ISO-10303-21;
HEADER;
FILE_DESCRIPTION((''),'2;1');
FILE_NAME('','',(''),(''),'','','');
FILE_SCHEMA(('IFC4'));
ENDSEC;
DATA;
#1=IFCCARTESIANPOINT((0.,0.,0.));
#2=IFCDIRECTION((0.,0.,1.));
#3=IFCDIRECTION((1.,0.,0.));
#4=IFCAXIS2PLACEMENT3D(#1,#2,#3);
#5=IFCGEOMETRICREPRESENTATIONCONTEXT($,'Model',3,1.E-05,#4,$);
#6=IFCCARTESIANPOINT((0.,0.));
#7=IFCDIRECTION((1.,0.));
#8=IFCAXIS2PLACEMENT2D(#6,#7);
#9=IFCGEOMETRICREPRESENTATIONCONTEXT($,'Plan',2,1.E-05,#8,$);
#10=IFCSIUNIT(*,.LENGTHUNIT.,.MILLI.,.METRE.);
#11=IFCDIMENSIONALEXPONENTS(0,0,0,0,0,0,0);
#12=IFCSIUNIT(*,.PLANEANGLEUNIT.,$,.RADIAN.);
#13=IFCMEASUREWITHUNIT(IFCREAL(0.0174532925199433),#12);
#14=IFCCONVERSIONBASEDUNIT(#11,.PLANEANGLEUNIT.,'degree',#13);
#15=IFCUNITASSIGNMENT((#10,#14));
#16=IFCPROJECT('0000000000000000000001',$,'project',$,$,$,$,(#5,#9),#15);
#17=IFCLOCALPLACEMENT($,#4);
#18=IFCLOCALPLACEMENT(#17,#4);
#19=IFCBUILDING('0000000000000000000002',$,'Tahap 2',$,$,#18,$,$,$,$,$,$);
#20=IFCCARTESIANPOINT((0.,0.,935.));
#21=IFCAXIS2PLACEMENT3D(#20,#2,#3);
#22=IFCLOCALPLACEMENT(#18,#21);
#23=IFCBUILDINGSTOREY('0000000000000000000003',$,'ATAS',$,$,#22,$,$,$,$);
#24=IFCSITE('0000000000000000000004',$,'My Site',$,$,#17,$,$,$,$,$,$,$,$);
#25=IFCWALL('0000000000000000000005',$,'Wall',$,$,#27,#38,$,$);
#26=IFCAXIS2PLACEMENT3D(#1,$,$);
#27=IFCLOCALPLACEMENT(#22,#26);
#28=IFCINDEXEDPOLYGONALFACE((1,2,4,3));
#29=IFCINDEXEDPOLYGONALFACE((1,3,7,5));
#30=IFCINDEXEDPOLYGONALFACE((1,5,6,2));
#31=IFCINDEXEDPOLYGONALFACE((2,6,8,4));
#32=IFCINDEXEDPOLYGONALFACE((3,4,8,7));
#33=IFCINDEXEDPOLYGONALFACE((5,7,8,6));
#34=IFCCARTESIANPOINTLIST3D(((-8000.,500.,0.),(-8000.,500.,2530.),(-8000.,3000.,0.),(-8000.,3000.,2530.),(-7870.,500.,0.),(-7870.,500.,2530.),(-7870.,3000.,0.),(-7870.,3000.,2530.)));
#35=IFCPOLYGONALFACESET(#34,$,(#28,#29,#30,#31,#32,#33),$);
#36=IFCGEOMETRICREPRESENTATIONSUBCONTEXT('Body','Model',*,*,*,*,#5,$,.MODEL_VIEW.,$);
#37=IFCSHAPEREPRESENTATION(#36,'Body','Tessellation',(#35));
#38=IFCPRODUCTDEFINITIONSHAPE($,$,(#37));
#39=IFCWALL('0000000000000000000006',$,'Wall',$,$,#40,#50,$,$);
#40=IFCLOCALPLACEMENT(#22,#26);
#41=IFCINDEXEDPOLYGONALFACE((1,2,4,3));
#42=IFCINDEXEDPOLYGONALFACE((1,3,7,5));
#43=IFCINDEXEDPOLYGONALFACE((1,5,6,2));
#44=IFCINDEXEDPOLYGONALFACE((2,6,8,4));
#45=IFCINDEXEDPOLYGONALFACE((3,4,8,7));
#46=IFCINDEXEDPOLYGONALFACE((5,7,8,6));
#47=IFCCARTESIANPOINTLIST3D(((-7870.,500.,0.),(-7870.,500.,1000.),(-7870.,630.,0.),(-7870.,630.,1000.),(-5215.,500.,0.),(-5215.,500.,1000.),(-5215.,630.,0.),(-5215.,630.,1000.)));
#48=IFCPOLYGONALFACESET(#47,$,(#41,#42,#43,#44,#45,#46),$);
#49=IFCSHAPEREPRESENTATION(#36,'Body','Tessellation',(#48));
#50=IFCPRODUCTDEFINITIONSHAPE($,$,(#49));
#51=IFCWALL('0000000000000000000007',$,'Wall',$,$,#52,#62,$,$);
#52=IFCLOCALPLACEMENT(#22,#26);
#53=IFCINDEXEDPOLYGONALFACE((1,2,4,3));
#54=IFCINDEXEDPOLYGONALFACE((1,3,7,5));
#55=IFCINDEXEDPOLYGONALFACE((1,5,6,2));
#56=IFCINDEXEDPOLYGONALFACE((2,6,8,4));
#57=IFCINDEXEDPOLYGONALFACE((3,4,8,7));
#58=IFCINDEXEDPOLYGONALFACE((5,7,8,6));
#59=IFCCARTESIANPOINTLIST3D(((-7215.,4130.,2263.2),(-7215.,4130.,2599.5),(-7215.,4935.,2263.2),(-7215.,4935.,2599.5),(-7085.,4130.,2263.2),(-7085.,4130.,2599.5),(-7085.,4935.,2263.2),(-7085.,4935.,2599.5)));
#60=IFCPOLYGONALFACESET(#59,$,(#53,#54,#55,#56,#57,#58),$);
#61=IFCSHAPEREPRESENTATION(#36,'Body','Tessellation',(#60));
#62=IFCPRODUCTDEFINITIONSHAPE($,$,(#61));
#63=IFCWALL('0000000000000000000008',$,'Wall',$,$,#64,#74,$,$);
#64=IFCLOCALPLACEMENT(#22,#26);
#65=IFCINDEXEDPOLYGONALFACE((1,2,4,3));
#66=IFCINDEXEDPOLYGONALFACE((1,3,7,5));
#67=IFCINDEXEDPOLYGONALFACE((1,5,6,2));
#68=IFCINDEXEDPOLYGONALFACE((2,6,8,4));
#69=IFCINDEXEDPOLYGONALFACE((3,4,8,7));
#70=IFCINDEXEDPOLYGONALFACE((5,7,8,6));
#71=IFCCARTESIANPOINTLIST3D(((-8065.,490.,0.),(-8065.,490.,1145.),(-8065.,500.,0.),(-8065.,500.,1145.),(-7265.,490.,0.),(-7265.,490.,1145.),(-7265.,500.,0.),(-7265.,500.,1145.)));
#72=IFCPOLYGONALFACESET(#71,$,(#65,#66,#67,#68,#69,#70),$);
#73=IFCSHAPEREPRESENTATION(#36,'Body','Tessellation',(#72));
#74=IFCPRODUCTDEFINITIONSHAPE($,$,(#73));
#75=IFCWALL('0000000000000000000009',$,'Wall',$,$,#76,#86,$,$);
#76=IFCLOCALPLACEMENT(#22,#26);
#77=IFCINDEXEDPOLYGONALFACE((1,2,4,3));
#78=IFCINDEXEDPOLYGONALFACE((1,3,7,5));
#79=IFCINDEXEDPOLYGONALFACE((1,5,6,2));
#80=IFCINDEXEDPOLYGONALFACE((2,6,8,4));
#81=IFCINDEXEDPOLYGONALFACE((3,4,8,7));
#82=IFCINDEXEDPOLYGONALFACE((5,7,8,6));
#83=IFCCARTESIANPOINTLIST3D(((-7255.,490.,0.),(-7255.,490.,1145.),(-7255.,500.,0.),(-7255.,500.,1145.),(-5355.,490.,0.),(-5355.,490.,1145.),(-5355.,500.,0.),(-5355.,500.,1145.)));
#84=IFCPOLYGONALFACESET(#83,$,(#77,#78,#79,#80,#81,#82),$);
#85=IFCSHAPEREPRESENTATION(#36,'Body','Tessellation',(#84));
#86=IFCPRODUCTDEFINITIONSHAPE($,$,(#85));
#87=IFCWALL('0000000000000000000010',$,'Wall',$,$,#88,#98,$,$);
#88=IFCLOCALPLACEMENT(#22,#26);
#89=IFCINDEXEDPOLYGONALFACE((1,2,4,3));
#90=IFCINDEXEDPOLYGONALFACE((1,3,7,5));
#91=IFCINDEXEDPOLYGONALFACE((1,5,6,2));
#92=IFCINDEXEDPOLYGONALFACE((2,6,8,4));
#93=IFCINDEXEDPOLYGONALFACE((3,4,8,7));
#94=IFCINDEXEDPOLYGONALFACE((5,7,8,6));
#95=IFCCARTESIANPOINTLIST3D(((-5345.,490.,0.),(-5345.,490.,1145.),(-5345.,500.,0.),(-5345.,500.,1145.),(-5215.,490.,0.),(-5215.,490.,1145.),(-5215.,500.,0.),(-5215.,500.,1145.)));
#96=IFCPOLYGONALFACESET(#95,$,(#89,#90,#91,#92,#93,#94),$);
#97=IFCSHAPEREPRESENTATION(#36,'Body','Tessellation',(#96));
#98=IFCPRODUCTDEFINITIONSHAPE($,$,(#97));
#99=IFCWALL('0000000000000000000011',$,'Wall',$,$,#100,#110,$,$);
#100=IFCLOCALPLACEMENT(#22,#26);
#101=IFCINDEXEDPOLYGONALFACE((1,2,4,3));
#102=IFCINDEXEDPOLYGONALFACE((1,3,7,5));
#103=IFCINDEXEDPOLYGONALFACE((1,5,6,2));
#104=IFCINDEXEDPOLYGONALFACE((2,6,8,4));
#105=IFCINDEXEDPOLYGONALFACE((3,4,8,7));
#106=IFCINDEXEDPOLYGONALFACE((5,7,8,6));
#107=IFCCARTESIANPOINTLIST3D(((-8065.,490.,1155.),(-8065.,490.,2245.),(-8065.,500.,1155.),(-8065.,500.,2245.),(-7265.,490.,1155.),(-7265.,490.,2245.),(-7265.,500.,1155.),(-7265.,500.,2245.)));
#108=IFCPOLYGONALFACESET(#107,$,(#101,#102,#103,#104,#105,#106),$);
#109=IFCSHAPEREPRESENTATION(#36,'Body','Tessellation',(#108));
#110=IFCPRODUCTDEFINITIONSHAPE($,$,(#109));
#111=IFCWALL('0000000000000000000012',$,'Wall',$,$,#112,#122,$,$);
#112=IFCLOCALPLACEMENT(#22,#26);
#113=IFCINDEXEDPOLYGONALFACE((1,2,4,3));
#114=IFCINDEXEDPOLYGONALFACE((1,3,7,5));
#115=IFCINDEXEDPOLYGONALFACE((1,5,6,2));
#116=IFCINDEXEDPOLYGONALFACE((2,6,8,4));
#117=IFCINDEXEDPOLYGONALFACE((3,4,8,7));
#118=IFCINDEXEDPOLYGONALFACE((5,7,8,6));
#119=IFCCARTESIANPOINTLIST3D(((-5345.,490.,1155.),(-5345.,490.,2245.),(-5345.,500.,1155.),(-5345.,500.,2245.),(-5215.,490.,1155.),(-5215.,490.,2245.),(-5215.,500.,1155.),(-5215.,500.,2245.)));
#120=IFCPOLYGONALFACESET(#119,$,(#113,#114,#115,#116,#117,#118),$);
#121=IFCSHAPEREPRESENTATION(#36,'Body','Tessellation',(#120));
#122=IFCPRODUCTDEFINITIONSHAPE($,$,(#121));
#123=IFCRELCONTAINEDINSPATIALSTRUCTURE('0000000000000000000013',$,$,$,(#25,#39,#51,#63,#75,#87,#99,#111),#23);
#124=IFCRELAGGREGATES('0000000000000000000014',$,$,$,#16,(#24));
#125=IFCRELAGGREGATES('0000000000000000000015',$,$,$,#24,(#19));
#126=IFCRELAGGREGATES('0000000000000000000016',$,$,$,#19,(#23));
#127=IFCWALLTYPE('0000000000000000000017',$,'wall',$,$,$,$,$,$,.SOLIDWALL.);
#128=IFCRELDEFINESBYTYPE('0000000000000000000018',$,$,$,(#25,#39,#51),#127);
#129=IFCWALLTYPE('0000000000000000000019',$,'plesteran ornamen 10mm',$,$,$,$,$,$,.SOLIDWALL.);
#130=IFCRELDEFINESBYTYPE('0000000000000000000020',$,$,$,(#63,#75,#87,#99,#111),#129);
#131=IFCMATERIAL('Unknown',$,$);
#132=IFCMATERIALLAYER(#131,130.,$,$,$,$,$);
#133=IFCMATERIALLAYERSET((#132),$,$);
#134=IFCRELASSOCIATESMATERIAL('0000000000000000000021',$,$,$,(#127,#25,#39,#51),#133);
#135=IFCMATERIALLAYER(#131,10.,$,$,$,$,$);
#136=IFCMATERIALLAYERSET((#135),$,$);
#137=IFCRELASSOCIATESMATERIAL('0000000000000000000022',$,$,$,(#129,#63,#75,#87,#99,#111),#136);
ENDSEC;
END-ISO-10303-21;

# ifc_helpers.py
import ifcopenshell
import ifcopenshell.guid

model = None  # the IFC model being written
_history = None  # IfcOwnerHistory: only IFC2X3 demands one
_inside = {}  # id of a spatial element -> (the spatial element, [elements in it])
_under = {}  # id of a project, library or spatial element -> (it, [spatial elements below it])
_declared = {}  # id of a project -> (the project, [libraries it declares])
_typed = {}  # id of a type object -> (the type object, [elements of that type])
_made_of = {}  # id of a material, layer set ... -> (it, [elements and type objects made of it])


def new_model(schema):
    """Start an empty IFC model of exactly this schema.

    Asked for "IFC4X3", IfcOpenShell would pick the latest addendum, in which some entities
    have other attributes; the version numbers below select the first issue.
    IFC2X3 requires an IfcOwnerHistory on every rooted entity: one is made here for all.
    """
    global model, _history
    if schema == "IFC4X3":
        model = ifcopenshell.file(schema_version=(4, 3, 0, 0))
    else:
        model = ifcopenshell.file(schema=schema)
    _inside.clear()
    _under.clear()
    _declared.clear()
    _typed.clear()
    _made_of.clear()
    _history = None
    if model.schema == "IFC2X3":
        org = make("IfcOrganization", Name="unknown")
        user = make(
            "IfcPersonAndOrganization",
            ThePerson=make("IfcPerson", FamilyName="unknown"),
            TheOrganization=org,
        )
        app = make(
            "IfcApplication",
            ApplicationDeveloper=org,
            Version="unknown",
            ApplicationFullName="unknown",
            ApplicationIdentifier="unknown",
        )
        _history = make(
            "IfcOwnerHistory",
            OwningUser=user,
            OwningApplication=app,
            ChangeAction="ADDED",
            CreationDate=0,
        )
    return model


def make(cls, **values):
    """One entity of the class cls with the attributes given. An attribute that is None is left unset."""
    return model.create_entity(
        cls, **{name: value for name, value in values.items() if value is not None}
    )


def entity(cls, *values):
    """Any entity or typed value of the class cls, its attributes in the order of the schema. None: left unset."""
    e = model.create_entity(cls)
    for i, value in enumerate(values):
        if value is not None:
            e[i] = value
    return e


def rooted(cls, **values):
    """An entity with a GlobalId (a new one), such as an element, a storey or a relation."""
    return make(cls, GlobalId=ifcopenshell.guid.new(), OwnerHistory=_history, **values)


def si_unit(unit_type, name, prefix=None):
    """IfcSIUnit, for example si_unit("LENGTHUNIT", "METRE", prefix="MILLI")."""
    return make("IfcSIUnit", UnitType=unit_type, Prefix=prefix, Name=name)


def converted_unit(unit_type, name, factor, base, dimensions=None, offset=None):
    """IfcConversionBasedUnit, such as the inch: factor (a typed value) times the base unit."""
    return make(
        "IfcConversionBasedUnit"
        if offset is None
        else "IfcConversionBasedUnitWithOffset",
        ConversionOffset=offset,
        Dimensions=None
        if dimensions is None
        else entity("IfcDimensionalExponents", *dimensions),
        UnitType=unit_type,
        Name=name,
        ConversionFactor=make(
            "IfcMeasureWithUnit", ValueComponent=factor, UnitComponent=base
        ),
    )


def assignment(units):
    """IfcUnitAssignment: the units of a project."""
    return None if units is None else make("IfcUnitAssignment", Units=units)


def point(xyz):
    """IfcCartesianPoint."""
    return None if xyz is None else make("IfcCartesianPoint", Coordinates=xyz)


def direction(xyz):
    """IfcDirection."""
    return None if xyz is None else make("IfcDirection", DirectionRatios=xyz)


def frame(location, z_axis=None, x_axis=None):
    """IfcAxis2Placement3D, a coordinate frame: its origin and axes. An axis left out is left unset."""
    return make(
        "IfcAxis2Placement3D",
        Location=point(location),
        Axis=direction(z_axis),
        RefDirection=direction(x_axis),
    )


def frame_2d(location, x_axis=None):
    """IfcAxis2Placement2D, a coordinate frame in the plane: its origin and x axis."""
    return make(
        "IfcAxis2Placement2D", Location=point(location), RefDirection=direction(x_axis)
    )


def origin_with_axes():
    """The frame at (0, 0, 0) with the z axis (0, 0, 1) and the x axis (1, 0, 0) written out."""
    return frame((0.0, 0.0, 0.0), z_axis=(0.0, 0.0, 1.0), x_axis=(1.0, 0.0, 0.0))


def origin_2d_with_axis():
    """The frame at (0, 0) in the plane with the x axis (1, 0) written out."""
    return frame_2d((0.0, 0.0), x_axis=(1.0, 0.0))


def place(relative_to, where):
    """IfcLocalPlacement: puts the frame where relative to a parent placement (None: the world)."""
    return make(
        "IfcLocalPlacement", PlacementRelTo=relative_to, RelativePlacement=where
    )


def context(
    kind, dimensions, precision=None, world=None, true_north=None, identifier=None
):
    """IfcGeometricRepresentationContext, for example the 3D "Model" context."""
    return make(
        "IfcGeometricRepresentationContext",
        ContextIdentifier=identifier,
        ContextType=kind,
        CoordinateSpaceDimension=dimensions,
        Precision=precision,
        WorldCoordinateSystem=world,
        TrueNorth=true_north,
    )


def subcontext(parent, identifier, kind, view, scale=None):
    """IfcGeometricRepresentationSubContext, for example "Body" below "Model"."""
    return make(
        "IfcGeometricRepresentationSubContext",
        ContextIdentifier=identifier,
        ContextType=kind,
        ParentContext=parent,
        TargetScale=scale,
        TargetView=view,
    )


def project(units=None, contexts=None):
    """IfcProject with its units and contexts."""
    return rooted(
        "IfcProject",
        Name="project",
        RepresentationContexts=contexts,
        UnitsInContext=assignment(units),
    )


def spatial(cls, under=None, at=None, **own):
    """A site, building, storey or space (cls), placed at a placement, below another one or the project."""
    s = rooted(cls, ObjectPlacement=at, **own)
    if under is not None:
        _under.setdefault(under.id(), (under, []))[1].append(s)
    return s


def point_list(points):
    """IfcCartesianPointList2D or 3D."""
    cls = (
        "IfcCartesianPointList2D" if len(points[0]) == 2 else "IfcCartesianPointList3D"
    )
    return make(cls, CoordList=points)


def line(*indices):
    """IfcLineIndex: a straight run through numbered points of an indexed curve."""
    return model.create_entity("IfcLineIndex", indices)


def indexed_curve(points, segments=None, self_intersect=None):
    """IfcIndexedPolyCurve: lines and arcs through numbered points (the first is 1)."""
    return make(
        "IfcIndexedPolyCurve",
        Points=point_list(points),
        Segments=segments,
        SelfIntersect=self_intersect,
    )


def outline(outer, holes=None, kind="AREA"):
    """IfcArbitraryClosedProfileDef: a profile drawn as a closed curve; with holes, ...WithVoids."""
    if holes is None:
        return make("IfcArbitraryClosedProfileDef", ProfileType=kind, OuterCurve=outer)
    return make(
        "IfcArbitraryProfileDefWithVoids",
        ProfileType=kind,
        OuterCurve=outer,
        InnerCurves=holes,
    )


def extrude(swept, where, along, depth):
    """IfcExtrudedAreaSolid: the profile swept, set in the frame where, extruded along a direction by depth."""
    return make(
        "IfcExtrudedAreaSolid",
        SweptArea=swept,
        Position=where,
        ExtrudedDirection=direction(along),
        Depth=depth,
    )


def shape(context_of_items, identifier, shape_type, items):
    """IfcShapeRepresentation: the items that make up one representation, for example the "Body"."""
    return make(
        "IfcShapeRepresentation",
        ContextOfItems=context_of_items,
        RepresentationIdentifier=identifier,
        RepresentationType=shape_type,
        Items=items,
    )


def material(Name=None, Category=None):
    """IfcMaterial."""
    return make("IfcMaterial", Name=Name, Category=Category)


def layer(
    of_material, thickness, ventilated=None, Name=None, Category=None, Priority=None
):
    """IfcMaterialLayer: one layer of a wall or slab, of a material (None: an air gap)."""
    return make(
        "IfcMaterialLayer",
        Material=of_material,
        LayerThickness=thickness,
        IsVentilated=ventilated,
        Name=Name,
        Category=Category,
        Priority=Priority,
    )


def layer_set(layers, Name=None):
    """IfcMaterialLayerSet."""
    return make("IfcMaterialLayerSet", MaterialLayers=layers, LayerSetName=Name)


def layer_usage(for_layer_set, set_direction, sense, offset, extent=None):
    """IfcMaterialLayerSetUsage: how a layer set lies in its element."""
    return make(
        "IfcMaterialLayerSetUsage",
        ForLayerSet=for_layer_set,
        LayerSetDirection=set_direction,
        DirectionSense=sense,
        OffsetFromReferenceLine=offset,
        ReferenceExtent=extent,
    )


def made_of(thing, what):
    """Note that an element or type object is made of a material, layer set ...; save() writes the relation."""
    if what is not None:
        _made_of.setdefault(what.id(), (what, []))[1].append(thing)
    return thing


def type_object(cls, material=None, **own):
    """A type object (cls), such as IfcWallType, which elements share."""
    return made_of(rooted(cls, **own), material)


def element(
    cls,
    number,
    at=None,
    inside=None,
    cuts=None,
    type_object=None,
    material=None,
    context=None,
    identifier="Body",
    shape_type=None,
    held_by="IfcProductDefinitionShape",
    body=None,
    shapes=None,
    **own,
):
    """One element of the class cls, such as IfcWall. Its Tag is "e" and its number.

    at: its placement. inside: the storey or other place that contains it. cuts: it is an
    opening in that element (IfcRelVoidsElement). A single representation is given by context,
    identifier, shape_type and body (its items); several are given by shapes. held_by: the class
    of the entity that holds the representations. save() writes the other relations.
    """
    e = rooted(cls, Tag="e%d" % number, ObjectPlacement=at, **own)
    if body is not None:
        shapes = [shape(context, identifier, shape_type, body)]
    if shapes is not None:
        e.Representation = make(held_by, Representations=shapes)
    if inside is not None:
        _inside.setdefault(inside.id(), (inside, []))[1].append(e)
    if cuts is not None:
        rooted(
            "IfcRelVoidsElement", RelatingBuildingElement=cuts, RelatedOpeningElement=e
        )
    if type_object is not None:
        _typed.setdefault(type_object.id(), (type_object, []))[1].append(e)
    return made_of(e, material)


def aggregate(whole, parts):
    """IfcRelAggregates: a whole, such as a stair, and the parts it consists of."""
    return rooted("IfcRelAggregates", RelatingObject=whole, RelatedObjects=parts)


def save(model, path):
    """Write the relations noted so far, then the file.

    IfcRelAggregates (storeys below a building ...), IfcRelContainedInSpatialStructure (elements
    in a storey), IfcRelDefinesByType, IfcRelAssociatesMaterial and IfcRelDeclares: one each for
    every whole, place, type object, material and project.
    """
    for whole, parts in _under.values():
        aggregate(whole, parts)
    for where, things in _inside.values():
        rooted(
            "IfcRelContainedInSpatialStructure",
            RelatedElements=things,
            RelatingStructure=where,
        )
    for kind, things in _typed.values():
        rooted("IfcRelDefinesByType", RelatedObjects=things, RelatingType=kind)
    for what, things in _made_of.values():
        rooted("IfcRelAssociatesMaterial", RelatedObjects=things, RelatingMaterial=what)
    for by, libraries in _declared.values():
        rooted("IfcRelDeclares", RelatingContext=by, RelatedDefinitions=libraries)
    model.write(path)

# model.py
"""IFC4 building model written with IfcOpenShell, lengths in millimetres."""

from ifc_helpers import new_model, entity, si_unit, converted_unit, frame, origin_with_axes, origin_2d_with_axis, place, context, subcontext, project, spatial, line, indexed_curve, outline, extrude, material, layer, layer_set, layer_usage, type_object, element, save


model = new_model("IFC4")

# Units and contexts
model_context = context("Model", 3, precision=1e-05, world=origin_with_axes())
plan_context = context("Plan", 2, precision=1e-05, world=origin_2d_with_axis())
body_context_1 = subcontext(model_context, "Body", "Model", "MODEL_VIEW")
ifc_project = project(units=[si_unit("LENGTHUNIT", "METRE", prefix="MILLI"), converted_unit("PLANEANGLEUNIT", "degree", entity("IfcReal", 0.0174532925199433), si_unit("PLANEANGLEUNIT", "RADIAN"), dimensions=[0, 0, 0, 0, 0, 0, 0])], contexts=[model_context, plan_context])

# Site, building, storey
site_placement = place(None, origin_with_axes())
site = spatial("IfcSite", under=ifc_project, at=site_placement, Name="My Site")
building_placement = place(site_placement, origin_with_axes())
building = spatial("IfcBuilding", under=site, at=building_placement, Name="Tahap 2")
storey_placement = place(building_placement, frame((0.0, 0.0, 935.0), z_axis=(0.0, 0.0, 1.0), x_axis=(1.0, 0.0, 0.0)))
storey = spatial("IfcBuildingStorey", under=building, at=storey_placement, Name="ATAS")

# Shared definitions
ifc_material_1 = material(Name="Unknown")
ifc_layer_1 = layer(ifc_material_1, 130.0)
ifc_layer_set_1 = layer_set([ifc_layer_1])
wall_type_1 = type_object("IfcWallType", Name="wall", PredefinedType="SOLIDWALL", material=ifc_layer_set_1)

# Wall
ifc_layer_usage_1 = layer_usage(ifc_layer_set_1, "AXIS2", "NEGATIVE", 0.0)
wall_1_placement = place(storey_placement, frame((-8000.0, 500.0, 0.0), z_axis=(0.0, 0.0, 1.0), x_axis=(0.0, 1.0, 0.0)))
element("IfcWall", 1, at=wall_1_placement, inside=storey, type_object=wall_type_1, material=ifc_layer_usage_1, Name="Wall", context=body_context_1, shape_type="SweptSolid", body=[
    extrude(outline(indexed_curve([(0.0, -130.0), (0.0, 0.0), (2500.0, 0.0), (2500.0, -130.0)], segments=[line(1, 2, 3, 4, 1)])), origin_with_axes(), (0.0, 0.0, 1.0), 2530.0),
])

# Walls
ifc_layer_usage_2 = layer_usage(ifc_layer_set_1, "AXIS2", "POSITIVE", 0.0)
wall_2_placement = place(storey_placement, frame((-7870.0, 500.0, 0.0), z_axis=(0.0, 0.0, 1.0), x_axis=(1.0, 0.0, 0.0)))
element("IfcWall", 2, at=wall_2_placement, inside=storey, type_object=wall_type_1, material=ifc_layer_usage_2, Name="Wall", context=body_context_1, shape_type="SweptSolid", body=[
    extrude(outline(indexed_curve([(0.0, 0.0), (0.0, 130.0), (2655.0, 130.0), (2655.0, 0.0)], segments=[line(1, 2, 3, 4, 1)])), origin_with_axes(), (0.0, 0.0, 1.0), 1000.0),
])
ifc_layer_usage_3 = layer_usage(ifc_layer_set_1, "AXIS2", "NEGATIVE", 0.0)
wall_3_placement = place(storey_placement, frame((-7085.0, 4935.0, 2263.2), z_axis=(0.0, 0.0, 1.0), x_axis=(-0.000001, -1.0, 0.0)))
element("IfcWall", 3, at=wall_3_placement, inside=storey, type_object=wall_type_1, material=ifc_layer_usage_3, Name="Wall", context=body_context_1, shape_type="SweptSolid", body=[
    extrude(outline(indexed_curve([(0.0, -130.0), (0.0, 0.0), (805.0, 0.0), (805.0, -130.0)], segments=[line(1, 2, 3, 4, 1)])), origin_with_axes(), (0.0, 0.0, 1.0), 336.3),
])
ifc_layer_2 = layer(ifc_material_1, 10.0)
ifc_layer_set_2 = layer_set([ifc_layer_2])
ifc_layer_usage_4 = layer_usage(ifc_layer_set_2, "AXIS2", "NEGATIVE", 0.0)
wall_type_2 = type_object("IfcWallType", Name="plesteran ornamen 10mm", PredefinedType="SOLIDWALL", material=ifc_layer_set_2)
wall_4_placement = place(storey_placement, frame((-8065.0, 500.0, 0.0), z_axis=(0.0, 0.0, 1.0), x_axis=(1.0, 0.0, 0.0)))
element("IfcWall", 4, at=wall_4_placement, inside=storey, type_object=wall_type_2, material=ifc_layer_usage_4, Name="Wall", context=body_context_1, shape_type="SweptSolid", body=[
    extrude(outline(indexed_curve([(0.0, -10.0), (0.0, 0.0), (800.0, 0.0), (800.0, -10.0)], segments=[line(1, 2, 3, 4, 1)])), origin_with_axes(), (0.0, 0.0, 1.0), 1145.0),
])
ifc_layer_usage_5 = layer_usage(ifc_layer_set_2, "AXIS2", "NEGATIVE", 0.0)
wall_5_placement = place(storey_placement, frame((-7255.0, 500.0, 0.0), z_axis=(0.0, 0.0, 1.0), x_axis=(1.0, 0.0, 0.0)))
element("IfcWall", 5, at=wall_5_placement, inside=storey, type_object=wall_type_2, material=ifc_layer_usage_5, Name="Wall", context=body_context_1, shape_type="SweptSolid", body=[
    extrude(outline(indexed_curve([(0.0, -10.0), (0.0, 0.0), (1900.0, 0.0), (1900.0, -10.0)], segments=[line(1, 2, 3, 4, 1)])), origin_with_axes(), (0.0, 0.0, 1.0), 1145.0),
])
ifc_layer_usage_6 = layer_usage(ifc_layer_set_2, "AXIS2", "NEGATIVE", 0.0)
wall_6_placement = place(storey_placement, frame((-5345.0, 500.0, 0.0), z_axis=(0.0, 0.0, 1.0), x_axis=(1.0, 0.0, 0.0)))
element("IfcWall", 6, at=wall_6_placement, inside=storey, type_object=wall_type_2, material=ifc_layer_usage_6, Name="Wall", context=body_context_1, shape_type="SweptSolid", body=[
    extrude(outline(indexed_curve([(0.0, -10.0), (0.0, 0.0), (130.0, 0.0), (130.0, -10.0)], segments=[line(1, 2, 3, 4, 1)])), origin_with_axes(), (0.0, 0.0, 1.0), 1145.0),
])
ifc_layer_usage_7 = layer_usage(ifc_layer_set_2, "AXIS2", "NEGATIVE", 0.0)
wall_7_placement = place(storey_placement, frame((-8065.0, 500.0, 1155.0), z_axis=(0.0, 0.0, 1.0), x_axis=(1.0, 0.0, 0.0)))
element("IfcWall", 7, at=wall_7_placement, inside=storey, type_object=wall_type_2, material=ifc_layer_usage_7, Name="Wall", context=body_context_1, shape_type="SweptSolid", body=[
    extrude(outline(indexed_curve([(0.0, -10.0), (0.0, 0.0), (800.0, 0.0), (800.0, -10.0)], segments=[line(1, 2, 3, 4, 1)])), origin_with_axes(), (0.0, 0.0, 1.0), 1090.0),
])
ifc_layer_usage_8 = layer_usage(ifc_layer_set_2, "AXIS2", "NEGATIVE", 0.0)
wall_8_placement = place(storey_placement, frame((-5345.0, 500.0, 1155.0), z_axis=(0.0, 0.0, 1.0), x_axis=(1.0, 0.0, 0.0)))
element("IfcWall", 8, at=wall_8_placement, inside=storey, type_object=wall_type_2, material=ifc_layer_usage_8, Name="Wall", context=body_context_1, shape_type="SweptSolid", body=[
    extrude(outline(indexed_curve([(0.0, -10.0), (0.0, 0.0), (130.0, 0.0), (130.0, -10.0)], segments=[line(1, 2, 3, 4, 1)])), origin_with_axes(), (0.0, 0.0, 1.0), 1090.0),
])

save(model, "model.ifc")
